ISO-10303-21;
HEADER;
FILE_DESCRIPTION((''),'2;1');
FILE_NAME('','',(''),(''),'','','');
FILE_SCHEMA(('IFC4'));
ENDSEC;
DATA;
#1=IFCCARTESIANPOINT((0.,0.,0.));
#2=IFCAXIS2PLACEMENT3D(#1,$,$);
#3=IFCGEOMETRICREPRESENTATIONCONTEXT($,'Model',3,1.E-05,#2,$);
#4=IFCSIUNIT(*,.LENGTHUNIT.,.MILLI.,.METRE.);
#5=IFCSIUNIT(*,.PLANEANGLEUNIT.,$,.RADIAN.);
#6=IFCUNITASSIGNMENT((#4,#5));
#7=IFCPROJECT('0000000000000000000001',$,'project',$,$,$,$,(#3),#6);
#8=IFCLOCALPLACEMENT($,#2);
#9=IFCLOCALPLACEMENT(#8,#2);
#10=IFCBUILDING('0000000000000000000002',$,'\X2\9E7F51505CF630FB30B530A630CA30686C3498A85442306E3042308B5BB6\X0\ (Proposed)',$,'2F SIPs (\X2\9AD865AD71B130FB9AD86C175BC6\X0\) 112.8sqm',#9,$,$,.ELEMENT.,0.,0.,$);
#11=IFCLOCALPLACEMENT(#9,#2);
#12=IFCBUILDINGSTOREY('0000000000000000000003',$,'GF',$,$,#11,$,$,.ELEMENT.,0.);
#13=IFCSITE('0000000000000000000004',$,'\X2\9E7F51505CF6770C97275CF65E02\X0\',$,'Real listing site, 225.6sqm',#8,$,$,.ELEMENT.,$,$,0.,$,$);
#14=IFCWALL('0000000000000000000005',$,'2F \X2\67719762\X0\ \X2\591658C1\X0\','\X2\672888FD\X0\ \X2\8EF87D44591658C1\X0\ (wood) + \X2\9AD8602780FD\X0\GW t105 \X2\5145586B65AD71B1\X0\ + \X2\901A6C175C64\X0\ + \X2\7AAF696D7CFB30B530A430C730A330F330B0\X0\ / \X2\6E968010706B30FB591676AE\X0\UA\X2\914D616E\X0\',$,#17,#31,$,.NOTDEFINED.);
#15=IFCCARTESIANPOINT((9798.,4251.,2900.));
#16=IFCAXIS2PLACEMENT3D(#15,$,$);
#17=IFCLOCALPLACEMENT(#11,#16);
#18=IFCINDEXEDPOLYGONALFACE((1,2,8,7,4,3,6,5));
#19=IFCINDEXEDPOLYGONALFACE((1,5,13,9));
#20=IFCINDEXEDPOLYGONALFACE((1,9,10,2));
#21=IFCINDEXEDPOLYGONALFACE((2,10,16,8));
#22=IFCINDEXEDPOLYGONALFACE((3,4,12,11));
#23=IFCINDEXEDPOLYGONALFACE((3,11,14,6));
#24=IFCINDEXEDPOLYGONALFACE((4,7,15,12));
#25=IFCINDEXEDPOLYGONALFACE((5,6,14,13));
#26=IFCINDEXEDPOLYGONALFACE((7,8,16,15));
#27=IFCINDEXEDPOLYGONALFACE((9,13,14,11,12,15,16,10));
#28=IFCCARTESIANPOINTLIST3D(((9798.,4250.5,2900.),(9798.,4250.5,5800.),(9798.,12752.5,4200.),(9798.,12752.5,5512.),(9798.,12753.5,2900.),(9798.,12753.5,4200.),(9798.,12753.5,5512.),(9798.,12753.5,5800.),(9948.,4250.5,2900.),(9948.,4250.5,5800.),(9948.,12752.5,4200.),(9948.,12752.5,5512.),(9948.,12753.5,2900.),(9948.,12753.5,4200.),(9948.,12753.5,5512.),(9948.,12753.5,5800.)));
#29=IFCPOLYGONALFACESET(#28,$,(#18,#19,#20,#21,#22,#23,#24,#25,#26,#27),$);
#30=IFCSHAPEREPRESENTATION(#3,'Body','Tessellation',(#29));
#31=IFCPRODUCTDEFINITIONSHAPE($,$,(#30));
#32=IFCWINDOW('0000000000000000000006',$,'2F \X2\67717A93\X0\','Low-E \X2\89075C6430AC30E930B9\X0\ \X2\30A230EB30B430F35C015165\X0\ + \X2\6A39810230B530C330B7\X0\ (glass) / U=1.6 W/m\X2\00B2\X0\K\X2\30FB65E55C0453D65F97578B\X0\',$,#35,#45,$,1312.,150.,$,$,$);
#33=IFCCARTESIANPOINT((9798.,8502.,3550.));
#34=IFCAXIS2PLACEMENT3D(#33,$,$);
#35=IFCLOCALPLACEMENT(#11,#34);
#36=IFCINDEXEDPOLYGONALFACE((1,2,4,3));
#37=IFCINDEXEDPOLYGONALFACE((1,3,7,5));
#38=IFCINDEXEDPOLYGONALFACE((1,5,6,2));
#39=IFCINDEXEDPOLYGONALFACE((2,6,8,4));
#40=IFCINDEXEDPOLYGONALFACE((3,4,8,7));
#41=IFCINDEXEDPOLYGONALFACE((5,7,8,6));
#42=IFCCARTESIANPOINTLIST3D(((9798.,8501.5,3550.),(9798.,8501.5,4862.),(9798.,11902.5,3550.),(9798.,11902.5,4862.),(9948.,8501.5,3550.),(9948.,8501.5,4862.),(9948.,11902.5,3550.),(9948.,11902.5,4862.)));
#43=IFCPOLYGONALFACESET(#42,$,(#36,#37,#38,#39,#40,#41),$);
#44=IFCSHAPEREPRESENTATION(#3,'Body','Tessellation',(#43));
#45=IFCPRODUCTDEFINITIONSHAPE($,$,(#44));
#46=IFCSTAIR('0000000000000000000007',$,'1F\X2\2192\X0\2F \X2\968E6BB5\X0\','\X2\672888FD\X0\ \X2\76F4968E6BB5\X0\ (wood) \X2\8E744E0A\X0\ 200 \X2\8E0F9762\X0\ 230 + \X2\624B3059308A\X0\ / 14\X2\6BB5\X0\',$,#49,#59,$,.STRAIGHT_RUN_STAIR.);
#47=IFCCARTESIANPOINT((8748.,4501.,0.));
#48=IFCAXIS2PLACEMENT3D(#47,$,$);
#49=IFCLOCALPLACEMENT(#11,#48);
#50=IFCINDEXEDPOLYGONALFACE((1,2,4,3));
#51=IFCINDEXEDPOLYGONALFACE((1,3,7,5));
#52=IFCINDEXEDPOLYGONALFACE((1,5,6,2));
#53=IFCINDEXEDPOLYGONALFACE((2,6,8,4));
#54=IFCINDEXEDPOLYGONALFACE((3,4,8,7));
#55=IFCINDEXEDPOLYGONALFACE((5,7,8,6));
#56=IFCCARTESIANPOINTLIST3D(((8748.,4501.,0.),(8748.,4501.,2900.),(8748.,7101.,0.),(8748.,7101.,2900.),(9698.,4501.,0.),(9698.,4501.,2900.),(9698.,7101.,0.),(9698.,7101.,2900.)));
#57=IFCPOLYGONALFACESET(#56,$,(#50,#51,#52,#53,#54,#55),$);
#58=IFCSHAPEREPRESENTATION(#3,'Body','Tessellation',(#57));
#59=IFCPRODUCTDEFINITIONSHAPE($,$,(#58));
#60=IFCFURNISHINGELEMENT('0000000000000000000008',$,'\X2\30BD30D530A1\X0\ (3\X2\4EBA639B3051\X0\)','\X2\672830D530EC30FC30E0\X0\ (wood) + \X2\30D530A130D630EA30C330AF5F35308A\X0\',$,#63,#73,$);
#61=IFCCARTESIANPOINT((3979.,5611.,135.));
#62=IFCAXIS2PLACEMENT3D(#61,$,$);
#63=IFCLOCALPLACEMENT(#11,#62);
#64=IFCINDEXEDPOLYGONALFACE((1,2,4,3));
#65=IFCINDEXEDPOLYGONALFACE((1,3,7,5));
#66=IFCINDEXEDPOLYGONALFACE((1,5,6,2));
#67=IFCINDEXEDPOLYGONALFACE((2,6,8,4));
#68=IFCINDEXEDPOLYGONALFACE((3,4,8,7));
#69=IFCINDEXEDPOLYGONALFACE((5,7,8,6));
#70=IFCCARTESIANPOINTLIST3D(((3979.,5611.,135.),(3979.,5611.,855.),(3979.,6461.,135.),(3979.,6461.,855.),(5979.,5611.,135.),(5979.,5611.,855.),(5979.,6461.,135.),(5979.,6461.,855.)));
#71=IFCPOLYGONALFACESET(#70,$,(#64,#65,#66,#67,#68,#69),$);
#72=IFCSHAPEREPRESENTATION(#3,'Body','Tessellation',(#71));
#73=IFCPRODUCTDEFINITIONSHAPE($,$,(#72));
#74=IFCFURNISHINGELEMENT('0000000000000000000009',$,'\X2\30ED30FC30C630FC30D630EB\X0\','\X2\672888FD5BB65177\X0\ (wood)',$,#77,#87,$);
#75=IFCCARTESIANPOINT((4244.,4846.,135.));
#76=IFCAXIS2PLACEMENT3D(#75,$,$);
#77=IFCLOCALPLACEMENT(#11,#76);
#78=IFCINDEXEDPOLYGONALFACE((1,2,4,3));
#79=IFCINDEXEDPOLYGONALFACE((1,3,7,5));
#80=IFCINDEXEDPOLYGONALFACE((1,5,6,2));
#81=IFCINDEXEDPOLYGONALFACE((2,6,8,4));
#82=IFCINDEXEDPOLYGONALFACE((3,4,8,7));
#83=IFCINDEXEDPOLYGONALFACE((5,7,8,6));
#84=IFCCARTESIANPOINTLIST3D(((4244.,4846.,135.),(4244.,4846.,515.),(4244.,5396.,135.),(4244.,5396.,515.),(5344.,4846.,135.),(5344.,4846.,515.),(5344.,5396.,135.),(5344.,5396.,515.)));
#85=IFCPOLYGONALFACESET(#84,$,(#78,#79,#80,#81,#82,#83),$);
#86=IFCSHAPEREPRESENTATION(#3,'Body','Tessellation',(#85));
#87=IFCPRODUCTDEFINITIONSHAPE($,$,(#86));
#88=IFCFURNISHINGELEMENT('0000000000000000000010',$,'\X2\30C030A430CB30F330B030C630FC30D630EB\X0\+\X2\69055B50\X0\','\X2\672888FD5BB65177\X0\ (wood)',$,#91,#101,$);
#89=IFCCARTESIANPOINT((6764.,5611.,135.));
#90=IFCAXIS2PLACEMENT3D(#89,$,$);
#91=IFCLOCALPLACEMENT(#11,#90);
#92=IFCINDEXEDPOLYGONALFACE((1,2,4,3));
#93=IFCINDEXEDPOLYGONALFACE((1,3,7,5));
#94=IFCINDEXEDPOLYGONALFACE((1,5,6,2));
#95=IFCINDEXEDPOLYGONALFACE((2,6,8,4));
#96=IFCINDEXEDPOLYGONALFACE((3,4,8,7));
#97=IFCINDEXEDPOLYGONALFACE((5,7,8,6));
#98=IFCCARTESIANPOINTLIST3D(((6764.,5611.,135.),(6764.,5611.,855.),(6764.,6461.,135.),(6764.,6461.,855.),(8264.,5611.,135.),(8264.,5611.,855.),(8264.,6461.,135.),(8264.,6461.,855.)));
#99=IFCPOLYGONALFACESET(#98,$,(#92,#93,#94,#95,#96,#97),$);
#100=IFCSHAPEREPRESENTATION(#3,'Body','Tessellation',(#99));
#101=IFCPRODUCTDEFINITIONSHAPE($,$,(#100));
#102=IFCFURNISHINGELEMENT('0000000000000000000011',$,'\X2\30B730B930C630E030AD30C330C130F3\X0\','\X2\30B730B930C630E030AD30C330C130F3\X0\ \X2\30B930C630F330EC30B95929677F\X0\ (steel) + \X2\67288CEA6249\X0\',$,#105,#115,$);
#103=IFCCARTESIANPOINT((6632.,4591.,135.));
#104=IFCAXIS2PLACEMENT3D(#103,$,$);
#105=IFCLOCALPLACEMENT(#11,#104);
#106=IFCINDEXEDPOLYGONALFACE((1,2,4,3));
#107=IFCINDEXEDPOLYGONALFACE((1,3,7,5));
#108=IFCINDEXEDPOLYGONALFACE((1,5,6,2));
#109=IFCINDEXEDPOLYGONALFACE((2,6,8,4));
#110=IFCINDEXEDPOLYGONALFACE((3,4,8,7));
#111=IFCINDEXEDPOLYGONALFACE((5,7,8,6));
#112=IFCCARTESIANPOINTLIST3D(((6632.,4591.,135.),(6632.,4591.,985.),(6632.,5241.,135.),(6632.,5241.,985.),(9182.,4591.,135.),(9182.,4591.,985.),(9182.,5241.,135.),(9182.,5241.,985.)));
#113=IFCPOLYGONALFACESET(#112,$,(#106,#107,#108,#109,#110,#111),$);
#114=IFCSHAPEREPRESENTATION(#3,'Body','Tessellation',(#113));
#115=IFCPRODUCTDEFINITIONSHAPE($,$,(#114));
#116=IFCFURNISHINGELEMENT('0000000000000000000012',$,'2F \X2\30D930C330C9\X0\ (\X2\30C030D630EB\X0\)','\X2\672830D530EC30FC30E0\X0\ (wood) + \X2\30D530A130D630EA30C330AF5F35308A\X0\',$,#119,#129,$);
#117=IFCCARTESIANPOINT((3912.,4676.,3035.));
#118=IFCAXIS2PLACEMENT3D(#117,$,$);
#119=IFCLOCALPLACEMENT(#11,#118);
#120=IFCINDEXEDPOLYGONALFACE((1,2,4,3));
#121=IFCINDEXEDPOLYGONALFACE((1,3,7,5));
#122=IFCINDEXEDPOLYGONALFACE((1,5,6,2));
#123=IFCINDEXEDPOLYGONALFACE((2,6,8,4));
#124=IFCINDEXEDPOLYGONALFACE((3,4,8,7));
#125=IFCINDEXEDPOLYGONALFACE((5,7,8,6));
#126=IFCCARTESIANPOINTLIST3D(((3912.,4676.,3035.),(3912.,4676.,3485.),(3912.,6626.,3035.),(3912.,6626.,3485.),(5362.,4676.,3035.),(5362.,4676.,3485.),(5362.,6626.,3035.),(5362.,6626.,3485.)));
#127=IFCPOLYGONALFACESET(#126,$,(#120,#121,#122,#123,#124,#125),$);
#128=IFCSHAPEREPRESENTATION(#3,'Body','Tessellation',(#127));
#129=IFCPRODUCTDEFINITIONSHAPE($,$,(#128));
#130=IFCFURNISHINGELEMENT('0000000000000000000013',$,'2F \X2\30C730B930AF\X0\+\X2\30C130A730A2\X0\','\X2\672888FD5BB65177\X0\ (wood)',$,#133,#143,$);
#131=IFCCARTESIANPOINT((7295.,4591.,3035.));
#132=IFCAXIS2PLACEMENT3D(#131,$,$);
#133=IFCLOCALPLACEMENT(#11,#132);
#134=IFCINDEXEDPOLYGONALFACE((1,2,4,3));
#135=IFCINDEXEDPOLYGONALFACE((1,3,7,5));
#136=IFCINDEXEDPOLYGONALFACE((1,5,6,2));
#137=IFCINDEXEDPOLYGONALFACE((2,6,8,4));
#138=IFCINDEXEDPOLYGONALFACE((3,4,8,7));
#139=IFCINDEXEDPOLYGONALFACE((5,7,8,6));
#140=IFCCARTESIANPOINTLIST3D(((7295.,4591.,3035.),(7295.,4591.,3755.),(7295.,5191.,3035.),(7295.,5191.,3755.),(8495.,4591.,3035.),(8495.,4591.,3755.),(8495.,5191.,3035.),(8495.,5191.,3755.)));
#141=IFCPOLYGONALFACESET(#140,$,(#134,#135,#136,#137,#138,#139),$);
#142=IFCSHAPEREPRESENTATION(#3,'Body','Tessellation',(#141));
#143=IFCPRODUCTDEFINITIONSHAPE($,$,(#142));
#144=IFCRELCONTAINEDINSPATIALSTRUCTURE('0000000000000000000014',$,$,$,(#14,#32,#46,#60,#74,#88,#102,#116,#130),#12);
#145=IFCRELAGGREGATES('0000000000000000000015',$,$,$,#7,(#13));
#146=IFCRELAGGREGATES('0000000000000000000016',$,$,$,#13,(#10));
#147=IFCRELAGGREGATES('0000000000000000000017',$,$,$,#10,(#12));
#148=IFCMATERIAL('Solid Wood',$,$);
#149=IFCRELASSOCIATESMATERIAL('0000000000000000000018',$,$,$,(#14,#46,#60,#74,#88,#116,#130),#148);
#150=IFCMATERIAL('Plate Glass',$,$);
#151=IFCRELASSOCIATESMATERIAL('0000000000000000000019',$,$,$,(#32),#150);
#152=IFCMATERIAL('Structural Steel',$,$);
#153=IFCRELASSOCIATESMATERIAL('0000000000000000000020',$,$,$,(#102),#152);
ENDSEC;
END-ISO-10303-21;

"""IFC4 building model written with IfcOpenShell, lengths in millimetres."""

from ifc_helpers import new_model, si_unit, frame, frame_2d, origin, place, context, project, spatial, rectangle, extrude, material, element, fill, save


model = new_model("IFC4")

# Units and contexts
model_context = context("Model", 3, precision=1e-05, world=origin())
ifc_project = project(units=[si_unit("LENGTHUNIT", "METRE", prefix="MILLI"), si_unit("PLANEANGLEUNIT", "RADIAN")], contexts=[model_context])

# Site, building, storey
site_placement = place(None, origin())
site = spatial("IfcSite", under=ifc_project, at=site_placement, Name="鹿児島県霧島市", ObjectType="Real listing site, 225.6sqm", CompositionType="ELEMENT", RefElevation=0.0)
building_placement = place(site_placement, origin())
building = spatial("IfcBuilding", under=site, at=building_placement, Name="鹿児島・サウナと水風呂のある家 (Proposed)", ObjectType="2F SIPs (高断熱・高気密) 112.8sqm", CompositionType="ELEMENT", ElevationOfRefHeight=0.0, ElevationOfTerrain=0.0)
storey_placement = place(building_placement, origin())
storey = spatial("IfcBuildingStorey", under=building, at=storey_placement, Name="GF", CompositionType="ELEMENT", Elevation=0.0)

# Shared definitions
ifc_material_1 = material(Name="Solid Wood")
ifc_material_2 = material(Name="Plate Glass")

# Wall, opening, window
wall_1_placement = place(storey_placement, frame((9798.0, 4251.0, 2900.0)))
wall_1 = element("IfcWall", 1, at=wall_1_placement, inside=storey, material=ifc_material_1, Name="2F 東面 外壁", Description="木製 軸組外壁 (wood) + 高性能GW t105 充填断熱 + 通気層 + 窯業系サイディング / 準耐火・外皮UA配慮", PredefinedType="NOTDEFINED", context=model_context, shape_type="SweptSolid", body=[
    extrude(rectangle(XDim=150.0, YDim=8503.0, at=frame_2d((75.0, 4251.0))), frame((9798.0, 4251.0, 2900.0)), (0.0, 0.0, 1.0), 2900.0),
])
opening_1_placement = place(storey_placement, frame((9798.0, 8502.0, 3550.0)))
opening_1 = element("IfcOpeningElement", 2, at=opening_1_placement, cuts=wall_1, PredefinedType="NOTDEFINED", context=model_context, shape_type="SweptSolid", body=[
    extrude(rectangle(XDim=150.0, YDim=3401.0, at=frame_2d((75.0, 1700.0))), frame((9798.0, 8502.0, 3550.0)), (0.0, 0.0, 1.0), 1312.0),
])
window_1_placement = place(storey_placement, frame((9798.0, 8502.0, 3550.0)))
window_1 = element("IfcWindow", 3, at=window_1_placement, inside=storey, material=ifc_material_2, Name="2F 東窓", Description="Low-E 複層ガラス アルゴン封入 + 樹脂サッシ (glass) / U=1.6 W/m²K・日射取得型", OverallHeight=1312.0, OverallWidth=150.0, context=model_context, shape_type="SweptSolid", body=[
    extrude(rectangle(XDim=150.0, YDim=3401.0, at=frame_2d((75.0, 1700.0))), frame((9798.0, 8502.0, 3550.0)), (0.0, 0.0, 1.0), 1312.0),
])
fill(opening_1, window_1)

# Stair
stair_placement = place(storey_placement, frame((8748.0, 4501.0, 0.0)))
element("IfcStair", 4, at=stair_placement, inside=storey, material=ifc_material_1, Name="1F→2F 階段", Description="木製 直階段 (wood) 蹴上 200 踏面 230 + 手すり / 14段", PredefinedType="STRAIGHT_RUN_STAIR", context=model_context, shape_type="SweptSolid", body=[
    extrude(rectangle(XDim=950.0, YDim=2600.0, at=frame_2d((475.0, 1300.0))), frame((8748.0, 4501.0, 0.0)), (0.0, 0.0, 1.0), 2900.0),
])

# Furnishing elements
furnishing_1_placement = place(storey_placement, frame((3979.0, 5611.0, 135.0)))
element("IfcFurnishingElement", 5, at=furnishing_1_placement, inside=storey, material=ifc_material_1, Name="ソファ (3人掛け)", Description="木フレーム (wood) + ファブリック張り", context=model_context, shape_type="SweptSolid", body=[
    extrude(rectangle(XDim=2000.0, YDim=850.0, at=frame_2d((1000.0, 425.0))), frame((3979.0, 5611.0, 135.0)), (0.0, 0.0, 1.0), 720.0),
])
furnishing_2_placement = place(storey_placement, frame((4244.0, 4846.0, 135.0)))
element("IfcFurnishingElement", 6, at=furnishing_2_placement, inside=storey, material=ifc_material_1, Name="ローテーブル", Description="木製家具 (wood)", context=model_context, shape_type="SweptSolid", body=[
    extrude(rectangle(XDim=1100.0, YDim=550.0, at=frame_2d((550.0, 275.0))), frame((4244.0, 4846.0, 135.0)), (0.0, 0.0, 1.0), 380.0),
])
furnishing_3_placement = place(storey_placement, frame((6764.0, 5611.0, 135.0)))
element("IfcFurnishingElement", 7, at=furnishing_3_placement, inside=storey, material=ifc_material_1, Name="ダイニングテーブル+椅子", Description="木製家具 (wood)", context=model_context, shape_type="SweptSolid", body=[
    extrude(rectangle(XDim=1500.0, YDim=850.0, at=frame_2d((750.0, 425.0))), frame((6764.0, 5611.0, 135.0)), (0.0, 0.0, 1.0), 720.0),
])
ifc_material_3 = material(Name="Structural Steel")
furnishing_4_placement = place(storey_placement, frame((6632.0, 4591.0, 135.0)))
element("IfcFurnishingElement", 8, at=furnishing_4_placement, inside=storey, material=ifc_material_3, Name="システムキッチン", Description="システムキッチン ステンレス天板 (steel) + 木質扉", context=model_context, shape_type="SweptSolid", body=[
    extrude(rectangle(XDim=2550.0, YDim=650.0, at=frame_2d((1275.0, 325.0))), frame((6632.0, 4591.0, 135.0)), (0.0, 0.0, 1.0), 850.0),
])
furnishing_5_placement = place(storey_placement, frame((3912.0, 4676.0, 3035.0)))
element("IfcFurnishingElement", 9, at=furnishing_5_placement, inside=storey, material=ifc_material_1, Name="2F ベッド (ダブル)", Description="木フレーム (wood) + ファブリック張り", context=model_context, shape_type="SweptSolid", body=[
    extrude(rectangle(XDim=1450.0, YDim=1950.0, at=frame_2d((725.0, 975.0))), frame((3912.0, 4676.0, 3035.0)), (0.0, 0.0, 1.0), 450.0),
])
furnishing_6_placement = place(storey_placement, frame((7295.0, 4591.0, 3035.0)))
element("IfcFurnishingElement", 10, at=furnishing_6_placement, inside=storey, material=ifc_material_1, Name="2F デスク+チェア", Description="木製家具 (wood)", context=model_context, shape_type="SweptSolid", body=[
    extrude(rectangle(XDim=1200.0, YDim=600.0, at=frame_2d((600.0, 300.0))), frame((7295.0, 4591.0, 3035.0)), (0.0, 0.0, 1.0), 720.0),
])

save(model, "model.ifc")
